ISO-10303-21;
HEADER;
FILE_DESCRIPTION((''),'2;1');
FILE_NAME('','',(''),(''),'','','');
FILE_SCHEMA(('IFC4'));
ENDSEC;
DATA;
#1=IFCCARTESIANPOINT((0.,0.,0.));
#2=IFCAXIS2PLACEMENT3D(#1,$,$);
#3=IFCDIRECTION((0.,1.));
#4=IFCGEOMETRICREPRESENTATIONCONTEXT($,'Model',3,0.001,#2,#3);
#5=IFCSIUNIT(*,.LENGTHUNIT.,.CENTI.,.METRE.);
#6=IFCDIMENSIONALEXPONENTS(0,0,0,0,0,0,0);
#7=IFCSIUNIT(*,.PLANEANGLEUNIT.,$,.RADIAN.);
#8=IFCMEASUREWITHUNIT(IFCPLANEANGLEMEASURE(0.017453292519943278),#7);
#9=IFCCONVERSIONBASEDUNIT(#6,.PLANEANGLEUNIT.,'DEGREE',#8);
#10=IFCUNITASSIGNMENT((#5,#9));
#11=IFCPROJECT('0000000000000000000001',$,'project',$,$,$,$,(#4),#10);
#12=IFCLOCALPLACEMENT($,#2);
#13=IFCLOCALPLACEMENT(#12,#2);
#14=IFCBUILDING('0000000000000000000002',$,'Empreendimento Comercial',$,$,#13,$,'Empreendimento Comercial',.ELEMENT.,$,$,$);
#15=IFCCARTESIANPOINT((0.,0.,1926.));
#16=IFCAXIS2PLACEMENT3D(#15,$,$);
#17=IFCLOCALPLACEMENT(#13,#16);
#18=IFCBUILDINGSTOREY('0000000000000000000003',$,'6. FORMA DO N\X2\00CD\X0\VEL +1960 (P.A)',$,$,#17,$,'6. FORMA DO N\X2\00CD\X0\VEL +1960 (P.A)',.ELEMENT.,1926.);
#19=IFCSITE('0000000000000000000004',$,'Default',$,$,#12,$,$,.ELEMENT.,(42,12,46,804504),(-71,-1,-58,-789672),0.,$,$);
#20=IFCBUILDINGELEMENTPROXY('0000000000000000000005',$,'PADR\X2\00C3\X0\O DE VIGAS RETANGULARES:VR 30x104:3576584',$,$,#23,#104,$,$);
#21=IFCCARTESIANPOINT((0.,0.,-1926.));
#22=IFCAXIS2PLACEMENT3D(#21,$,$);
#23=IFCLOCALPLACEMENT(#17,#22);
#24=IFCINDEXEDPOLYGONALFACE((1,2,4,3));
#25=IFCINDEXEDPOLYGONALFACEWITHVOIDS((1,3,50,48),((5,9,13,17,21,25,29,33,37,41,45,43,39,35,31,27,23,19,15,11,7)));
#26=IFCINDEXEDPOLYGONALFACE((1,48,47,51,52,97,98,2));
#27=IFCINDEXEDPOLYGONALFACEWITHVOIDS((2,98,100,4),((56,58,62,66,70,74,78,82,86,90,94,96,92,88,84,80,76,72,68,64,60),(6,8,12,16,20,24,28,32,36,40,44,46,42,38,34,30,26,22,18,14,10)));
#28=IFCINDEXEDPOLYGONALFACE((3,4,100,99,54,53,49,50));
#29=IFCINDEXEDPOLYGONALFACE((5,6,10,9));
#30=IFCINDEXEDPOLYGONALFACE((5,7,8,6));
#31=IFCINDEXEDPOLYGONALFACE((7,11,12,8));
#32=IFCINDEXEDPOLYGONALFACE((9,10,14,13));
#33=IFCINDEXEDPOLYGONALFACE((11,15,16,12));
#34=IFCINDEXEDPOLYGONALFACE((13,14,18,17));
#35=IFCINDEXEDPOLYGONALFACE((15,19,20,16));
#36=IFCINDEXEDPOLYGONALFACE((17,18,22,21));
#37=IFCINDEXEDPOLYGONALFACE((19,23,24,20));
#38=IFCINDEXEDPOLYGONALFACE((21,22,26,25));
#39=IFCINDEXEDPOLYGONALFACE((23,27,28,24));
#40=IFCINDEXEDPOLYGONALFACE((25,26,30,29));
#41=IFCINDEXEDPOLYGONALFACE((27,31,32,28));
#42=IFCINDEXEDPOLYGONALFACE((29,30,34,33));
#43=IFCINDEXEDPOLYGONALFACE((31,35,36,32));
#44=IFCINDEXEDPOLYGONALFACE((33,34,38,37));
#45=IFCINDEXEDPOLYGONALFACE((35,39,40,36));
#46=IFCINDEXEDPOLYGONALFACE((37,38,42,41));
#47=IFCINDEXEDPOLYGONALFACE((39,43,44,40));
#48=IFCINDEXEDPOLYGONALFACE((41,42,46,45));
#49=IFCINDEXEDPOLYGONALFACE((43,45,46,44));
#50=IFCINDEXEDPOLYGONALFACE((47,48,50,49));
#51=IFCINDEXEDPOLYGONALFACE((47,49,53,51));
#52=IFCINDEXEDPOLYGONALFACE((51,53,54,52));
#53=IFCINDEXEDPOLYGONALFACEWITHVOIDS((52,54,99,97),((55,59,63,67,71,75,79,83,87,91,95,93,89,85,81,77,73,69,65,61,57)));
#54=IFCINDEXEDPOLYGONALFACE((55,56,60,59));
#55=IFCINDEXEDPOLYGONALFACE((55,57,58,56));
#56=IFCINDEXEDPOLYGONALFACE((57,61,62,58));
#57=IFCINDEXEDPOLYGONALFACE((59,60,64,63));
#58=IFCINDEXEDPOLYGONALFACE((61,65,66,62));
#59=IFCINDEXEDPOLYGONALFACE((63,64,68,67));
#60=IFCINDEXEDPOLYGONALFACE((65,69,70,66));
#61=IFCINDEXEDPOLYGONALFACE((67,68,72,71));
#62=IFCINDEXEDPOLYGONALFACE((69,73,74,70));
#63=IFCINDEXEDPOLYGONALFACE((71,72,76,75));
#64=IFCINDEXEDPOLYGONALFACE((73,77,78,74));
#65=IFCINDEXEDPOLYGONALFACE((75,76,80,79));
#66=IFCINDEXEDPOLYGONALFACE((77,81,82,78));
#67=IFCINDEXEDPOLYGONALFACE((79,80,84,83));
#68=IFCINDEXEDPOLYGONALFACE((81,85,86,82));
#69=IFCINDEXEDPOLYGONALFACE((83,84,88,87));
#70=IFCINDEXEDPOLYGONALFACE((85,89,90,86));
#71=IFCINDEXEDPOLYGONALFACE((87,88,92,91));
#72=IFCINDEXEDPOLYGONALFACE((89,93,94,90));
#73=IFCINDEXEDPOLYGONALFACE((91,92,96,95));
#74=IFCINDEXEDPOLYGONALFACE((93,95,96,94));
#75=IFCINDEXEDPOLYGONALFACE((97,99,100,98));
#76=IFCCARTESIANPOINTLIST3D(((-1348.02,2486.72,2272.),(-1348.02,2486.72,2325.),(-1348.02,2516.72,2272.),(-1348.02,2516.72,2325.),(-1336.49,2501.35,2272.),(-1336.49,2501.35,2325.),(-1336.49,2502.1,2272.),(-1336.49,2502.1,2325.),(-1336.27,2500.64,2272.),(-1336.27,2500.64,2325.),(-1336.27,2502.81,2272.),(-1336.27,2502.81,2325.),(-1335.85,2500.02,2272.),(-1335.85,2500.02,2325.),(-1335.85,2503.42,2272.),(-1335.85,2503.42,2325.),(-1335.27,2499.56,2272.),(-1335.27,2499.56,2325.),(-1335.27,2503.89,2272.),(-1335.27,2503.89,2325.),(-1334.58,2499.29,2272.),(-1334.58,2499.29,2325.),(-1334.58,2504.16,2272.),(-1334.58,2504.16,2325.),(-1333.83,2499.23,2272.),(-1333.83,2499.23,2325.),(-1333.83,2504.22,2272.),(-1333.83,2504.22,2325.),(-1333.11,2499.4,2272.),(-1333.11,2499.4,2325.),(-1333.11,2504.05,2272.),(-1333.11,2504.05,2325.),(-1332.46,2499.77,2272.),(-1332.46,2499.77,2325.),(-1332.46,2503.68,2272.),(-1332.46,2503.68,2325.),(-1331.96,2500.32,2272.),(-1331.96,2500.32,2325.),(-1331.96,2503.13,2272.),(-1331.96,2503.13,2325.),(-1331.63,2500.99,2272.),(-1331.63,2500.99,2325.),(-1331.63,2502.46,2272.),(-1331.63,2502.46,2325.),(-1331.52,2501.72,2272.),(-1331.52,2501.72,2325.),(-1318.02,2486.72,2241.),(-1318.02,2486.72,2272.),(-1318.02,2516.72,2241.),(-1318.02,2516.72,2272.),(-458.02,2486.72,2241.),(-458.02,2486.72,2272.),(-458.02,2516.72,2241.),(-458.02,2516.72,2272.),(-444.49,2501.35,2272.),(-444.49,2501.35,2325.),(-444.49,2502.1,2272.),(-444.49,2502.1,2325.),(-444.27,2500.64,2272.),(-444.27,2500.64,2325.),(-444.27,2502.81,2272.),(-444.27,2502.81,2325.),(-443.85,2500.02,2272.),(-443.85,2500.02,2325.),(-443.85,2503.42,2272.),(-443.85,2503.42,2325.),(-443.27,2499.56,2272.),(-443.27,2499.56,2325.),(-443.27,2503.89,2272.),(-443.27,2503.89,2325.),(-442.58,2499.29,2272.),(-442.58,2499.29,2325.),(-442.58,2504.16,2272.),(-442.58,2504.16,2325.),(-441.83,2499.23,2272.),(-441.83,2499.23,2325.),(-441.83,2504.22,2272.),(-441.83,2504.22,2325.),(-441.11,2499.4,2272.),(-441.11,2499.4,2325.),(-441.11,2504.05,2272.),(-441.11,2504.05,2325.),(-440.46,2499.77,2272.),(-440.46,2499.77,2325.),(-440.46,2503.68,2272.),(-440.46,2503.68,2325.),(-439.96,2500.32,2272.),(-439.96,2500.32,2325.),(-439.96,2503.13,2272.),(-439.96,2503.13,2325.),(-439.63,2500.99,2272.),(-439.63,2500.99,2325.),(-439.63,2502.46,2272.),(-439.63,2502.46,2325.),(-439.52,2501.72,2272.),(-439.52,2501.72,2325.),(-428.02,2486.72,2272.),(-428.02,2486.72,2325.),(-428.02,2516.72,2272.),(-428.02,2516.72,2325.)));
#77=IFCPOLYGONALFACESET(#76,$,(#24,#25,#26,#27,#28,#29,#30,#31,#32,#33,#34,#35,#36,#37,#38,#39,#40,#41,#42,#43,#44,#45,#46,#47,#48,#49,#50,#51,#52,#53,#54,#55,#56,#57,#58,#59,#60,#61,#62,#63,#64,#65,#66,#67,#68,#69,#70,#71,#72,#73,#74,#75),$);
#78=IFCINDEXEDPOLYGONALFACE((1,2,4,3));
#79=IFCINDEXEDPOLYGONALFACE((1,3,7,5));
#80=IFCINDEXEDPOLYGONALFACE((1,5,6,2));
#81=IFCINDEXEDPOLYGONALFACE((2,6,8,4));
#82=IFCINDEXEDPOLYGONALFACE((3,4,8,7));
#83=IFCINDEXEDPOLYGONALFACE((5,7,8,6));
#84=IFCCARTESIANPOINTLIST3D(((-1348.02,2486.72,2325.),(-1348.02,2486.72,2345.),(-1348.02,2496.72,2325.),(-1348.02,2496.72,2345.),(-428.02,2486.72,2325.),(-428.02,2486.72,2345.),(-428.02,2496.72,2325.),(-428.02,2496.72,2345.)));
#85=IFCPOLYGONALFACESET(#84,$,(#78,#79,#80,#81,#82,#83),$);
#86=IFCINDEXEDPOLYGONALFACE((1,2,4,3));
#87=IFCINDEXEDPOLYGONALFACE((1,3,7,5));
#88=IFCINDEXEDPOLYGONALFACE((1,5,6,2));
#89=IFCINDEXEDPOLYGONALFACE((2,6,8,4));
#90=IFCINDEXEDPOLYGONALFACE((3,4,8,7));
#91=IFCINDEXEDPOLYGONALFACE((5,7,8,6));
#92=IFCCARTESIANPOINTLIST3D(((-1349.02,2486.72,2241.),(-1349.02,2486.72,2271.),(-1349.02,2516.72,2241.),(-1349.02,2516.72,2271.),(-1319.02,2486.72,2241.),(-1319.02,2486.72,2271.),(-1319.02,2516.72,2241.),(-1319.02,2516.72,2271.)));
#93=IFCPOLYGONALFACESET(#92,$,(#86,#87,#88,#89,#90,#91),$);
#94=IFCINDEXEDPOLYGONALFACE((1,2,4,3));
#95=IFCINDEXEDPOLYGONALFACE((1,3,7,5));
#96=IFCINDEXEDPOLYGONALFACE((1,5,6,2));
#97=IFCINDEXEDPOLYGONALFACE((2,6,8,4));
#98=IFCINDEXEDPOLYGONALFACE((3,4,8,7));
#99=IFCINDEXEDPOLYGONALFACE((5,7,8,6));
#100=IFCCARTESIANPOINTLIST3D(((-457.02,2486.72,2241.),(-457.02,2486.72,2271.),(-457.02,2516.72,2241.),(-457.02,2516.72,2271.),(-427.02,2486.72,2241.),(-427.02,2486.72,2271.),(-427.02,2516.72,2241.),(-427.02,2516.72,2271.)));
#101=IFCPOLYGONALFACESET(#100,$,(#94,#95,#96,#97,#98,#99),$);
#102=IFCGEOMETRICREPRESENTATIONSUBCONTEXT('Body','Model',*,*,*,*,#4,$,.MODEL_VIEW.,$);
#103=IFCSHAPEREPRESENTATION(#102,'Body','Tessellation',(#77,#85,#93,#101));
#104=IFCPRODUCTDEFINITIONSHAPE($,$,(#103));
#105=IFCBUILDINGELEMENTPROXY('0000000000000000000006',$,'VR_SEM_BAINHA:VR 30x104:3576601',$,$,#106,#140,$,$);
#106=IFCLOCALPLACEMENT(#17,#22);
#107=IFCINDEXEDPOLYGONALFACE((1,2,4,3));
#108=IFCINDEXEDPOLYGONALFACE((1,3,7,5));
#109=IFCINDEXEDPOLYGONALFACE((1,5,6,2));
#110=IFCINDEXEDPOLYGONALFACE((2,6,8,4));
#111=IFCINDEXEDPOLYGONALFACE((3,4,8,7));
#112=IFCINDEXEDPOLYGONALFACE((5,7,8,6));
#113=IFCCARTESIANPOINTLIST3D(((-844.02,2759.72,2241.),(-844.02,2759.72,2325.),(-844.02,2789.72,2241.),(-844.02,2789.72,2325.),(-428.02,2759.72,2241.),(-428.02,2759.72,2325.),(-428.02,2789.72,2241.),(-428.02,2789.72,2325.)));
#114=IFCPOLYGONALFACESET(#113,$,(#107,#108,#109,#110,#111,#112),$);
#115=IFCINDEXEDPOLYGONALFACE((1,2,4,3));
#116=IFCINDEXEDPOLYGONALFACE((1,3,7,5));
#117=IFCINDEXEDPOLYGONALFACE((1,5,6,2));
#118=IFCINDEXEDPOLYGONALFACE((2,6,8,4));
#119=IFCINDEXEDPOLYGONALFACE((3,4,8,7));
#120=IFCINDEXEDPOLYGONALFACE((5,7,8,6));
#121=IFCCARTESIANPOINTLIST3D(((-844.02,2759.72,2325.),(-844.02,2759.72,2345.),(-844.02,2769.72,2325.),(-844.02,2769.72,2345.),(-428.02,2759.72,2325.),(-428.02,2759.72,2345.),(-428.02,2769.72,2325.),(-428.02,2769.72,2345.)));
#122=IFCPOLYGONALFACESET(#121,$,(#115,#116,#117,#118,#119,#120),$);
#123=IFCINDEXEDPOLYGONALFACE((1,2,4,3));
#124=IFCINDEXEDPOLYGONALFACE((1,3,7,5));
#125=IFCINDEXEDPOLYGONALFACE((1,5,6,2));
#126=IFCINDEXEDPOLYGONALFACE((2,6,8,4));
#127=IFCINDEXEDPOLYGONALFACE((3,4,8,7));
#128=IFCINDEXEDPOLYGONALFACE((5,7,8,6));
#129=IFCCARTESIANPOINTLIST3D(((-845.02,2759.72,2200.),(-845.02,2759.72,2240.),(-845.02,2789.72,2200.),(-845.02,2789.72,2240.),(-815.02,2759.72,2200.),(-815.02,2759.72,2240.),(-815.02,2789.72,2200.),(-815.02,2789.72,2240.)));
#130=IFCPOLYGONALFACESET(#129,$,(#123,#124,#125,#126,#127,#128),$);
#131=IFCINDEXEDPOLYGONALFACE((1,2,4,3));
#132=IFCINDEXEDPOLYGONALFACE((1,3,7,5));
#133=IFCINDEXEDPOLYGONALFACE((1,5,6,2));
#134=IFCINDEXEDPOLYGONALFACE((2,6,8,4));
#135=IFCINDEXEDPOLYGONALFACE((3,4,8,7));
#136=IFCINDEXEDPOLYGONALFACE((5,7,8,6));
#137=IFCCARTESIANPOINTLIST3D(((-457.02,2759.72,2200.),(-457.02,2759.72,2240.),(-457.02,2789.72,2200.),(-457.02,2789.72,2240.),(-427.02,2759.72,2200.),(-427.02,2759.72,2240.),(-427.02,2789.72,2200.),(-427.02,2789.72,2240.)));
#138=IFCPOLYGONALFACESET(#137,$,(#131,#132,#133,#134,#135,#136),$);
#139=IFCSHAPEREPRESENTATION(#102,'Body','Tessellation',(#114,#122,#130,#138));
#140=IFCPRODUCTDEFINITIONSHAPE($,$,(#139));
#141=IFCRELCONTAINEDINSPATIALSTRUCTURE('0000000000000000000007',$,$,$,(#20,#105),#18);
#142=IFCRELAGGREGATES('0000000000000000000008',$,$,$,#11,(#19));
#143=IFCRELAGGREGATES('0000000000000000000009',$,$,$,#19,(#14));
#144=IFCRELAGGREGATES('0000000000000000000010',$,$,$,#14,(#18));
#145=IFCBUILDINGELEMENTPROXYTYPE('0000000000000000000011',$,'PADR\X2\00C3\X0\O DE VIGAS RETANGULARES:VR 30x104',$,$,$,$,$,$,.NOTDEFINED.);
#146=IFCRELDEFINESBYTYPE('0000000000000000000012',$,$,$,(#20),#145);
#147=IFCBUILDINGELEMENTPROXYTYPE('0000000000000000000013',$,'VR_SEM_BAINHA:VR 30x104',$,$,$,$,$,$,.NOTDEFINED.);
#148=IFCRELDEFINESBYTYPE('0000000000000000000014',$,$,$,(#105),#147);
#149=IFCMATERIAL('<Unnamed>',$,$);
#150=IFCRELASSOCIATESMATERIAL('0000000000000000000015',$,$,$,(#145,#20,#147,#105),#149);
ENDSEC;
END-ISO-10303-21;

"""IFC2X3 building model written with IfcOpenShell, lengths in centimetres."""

from ifc_helpers import new_model, entity, si_unit, converted_unit, direction, frame, frame_2d, origin, origin_2d_with_axis, place, context, subcontext, project, spatial, polyline, rectangle, circle, outline, extrude, source, transform, mapped, material, type_object, type_shapes, element, save


model = new_model("IFC2X3")

# Units and contexts
model_context = context("Model", 3, precision=0.001, world=origin(), true_north=direction((0.0, 1.0)))
body_context = subcontext(model_context, "Body", "Model", "MODEL_VIEW")
ifc_project = project(units=[si_unit("LENGTHUNIT", "METRE", prefix="CENTI"), converted_unit("PLANEANGLEUNIT", "DEGREE", entity("IfcPlaneAngleMeasure", 0.017453292519943278), si_unit("PLANEANGLEUNIT", "RADIAN"), dimensions=[0, 0, 0, 0, 0, 0, 0])], contexts=[model_context])

# Site, building, storey
site_placement = place(None, origin())
site = spatial("IfcSite", under=ifc_project, at=site_placement, Name="Default", CompositionType="ELEMENT", RefLatitude=(42, 12, 46, 804504), RefLongitude=(-71, -1, -58, -789672), RefElevation=0.0)
building_placement = place(site_placement, origin())
building = spatial("IfcBuilding", under=site, at=building_placement, Name="Empreendimento Comercial", LongName="Empreendimento Comercial", CompositionType="ELEMENT")
storey_placement = place(building_placement, frame((0.0, 0.0, 1926.0)))
storey = spatial("IfcBuildingStorey", under=building, at=storey_placement, Name="6. FORMA DO NÍVEL +1960 (P.A)", LongName="6. FORMA DO NÍVEL +1960 (P.A)", CompositionType="ELEMENT", Elevation=1926.0)

# Shared definitions
ifc_material = material(Name="<Unnamed>")

# Building element proxy, openings
building_element_proxy_type_1 = type_object("IfcBuildingElementProxyType", Name="PADRÃO DE VIGAS RETANGULARES:VR 30x104", PredefinedType="NOTDEFINED", material=ifc_material)
shared_shape_1 = source(origin(), body_context, "Body", "SweptSolid", [
    extrude(outline(polyline([(-460.0, -47.5), (460.0, -47.5), (460.0, 5.5), (430.0, 5.5), (430.0, 36.5), (-430.0, 36.5), (-430.0, 5.5), (-460.0, 5.5), (-460.0, -47.5)])), frame((-888.02, 2486.72, 2277.5), z_axis=(0.0, 1.0, 0.0), x_axis=(1.0, 0.0, 0.0)), (0.0, 0.0, 1.0), 30.0),
    extrude(rectangle(XDim=10.0, YDim=920.0, at=frame_2d((0.0, 0.0), x_axis=(1.0, 0.0))), frame((-888.02, 2491.72, 2325.0), z_axis=(0.0, 0.0, 1.0), x_axis=(0.0, 1.0, 0.0)), (0.0, 0.0, 1.0), 20.0),
    extrude(rectangle(XDim=30.0, YDim=30.0, at=frame_2d((0.0, 0.0), x_axis=(1.0, 0.0))), frame((-1334.02, 2501.72, 2241.0), z_axis=(0.0, 0.0, 1.0), x_axis=(-1.0, 0.0, 0.0)), (0.0, 0.0, 1.0), 30.0),
    extrude(rectangle(XDim=30.0, YDim=30.0, at=origin_2d_with_axis()), frame((-442.02, 2501.72, 2241.0), z_axis=(0.0, 0.0, 1.0), x_axis=(-1.0, 0.0, 0.0)), (0.0, 0.0, 1.0), 30.0),
])
type_shapes(building_element_proxy_type_1, [shared_shape_1])
proxy_1_placement = place(storey_placement, frame((0.0, 0.0, -1926.0)))
proxy_1 = element("IfcBuildingElementProxy", 1, at=proxy_1_placement, inside=storey, type_object=building_element_proxy_type_1, material=ifc_material, Name="PADRÃO DE VIGAS RETANGULARES:VR 30x104:3576584", context=body_context, shape_type="MappedRepresentation", body=[
    mapped(shared_shape_1, transform((0.0, 0.0, 0.0), scale=1.0)),
])
opening_1_placement = place(storey_placement, frame((0.0, 0.0, -1926.0)))
element("IfcOpeningElement", 2, at=opening_1_placement, cuts=proxy_1, ObjectType="Opening", context=body_context, shape_type="SweptSolid", body=[
    extrude(circle(Radius=2.5, at=origin_2d_with_axis()), frame((-442.02, 2501.72, 2272.0)), (0.0, 0.0, 1.0), 53.0),
])
opening_2_placement = place(storey_placement, frame((0.0, 0.0, -1926.0)))
element("IfcOpeningElement", 3, at=opening_2_placement, cuts=proxy_1, ObjectType="Opening", context=body_context, shape_type="SweptSolid", body=[
    extrude(circle(Radius=2.5, at=origin_2d_with_axis()), frame((-1334.02, 2501.72, 2272.0)), (0.0, 0.0, 1.0), 53.0),
])

# Building element proxy
building_element_proxy_type_2 = type_object("IfcBuildingElementProxyType", Name="VR_SEM_BAINHA:VR 30x104", PredefinedType="NOTDEFINED", material=ifc_material)
shared_shape_2 = source(origin(), body_context, "Body", "SweptSolid", [
    extrude(rectangle(XDim=30.0, YDim=416.0, at=frame_2d((5.0, 8.0), x_axis=(1.0, 0.0))), frame((-628.02, 2769.72, 2241.0), z_axis=(0.0, 0.0, 1.0), x_axis=(0.0, 1.0, 0.0)), (0.0, 0.0, 1.0), 84.0),
    extrude(rectangle(XDim=10.0, YDim=416.0, at=frame_2d((0.0, 0.0), x_axis=(1.0, 0.0))), frame((-636.02, 2764.72, 2325.0), z_axis=(0.0, 0.0, 1.0), x_axis=(0.0, 1.0, 0.0)), (0.0, 0.0, 1.0), 20.0),
    extrude(rectangle(XDim=30.0, YDim=30.0, at=frame_2d((0.0, 0.0), x_axis=(1.0, 0.0))), frame((-830.02, 2774.72, 2200.0), z_axis=(0.0, 0.0, 1.0), x_axis=(-1.0, 0.0, 0.0)), (0.0, 0.0, 1.0), 40.0),
    extrude(rectangle(XDim=30.0, YDim=30.0, at=frame_2d((0.0, 0.0), x_axis=(1.0, 0.0))), frame((-442.02, 2774.72, 2200.0), z_axis=(0.0, 0.0, 1.0), x_axis=(-1.0, 0.0, 0.0)), (0.0, 0.0, 1.0), 40.0),
])
type_shapes(building_element_proxy_type_2, [shared_shape_2])
proxy_2_placement = place(storey_placement, frame((0.0, 0.0, -1926.0)))
element("IfcBuildingElementProxy", 4, at=proxy_2_placement, inside=storey, type_object=building_element_proxy_type_2, material=ifc_material, Name="VR_SEM_BAINHA:VR 30x104:3576601", context=body_context, shape_type="MappedRepresentation", body=[
    mapped(shared_shape_2, transform((0.0, 0.0, 0.0), scale=1.0)),
])

save(model, "model.ifc")
